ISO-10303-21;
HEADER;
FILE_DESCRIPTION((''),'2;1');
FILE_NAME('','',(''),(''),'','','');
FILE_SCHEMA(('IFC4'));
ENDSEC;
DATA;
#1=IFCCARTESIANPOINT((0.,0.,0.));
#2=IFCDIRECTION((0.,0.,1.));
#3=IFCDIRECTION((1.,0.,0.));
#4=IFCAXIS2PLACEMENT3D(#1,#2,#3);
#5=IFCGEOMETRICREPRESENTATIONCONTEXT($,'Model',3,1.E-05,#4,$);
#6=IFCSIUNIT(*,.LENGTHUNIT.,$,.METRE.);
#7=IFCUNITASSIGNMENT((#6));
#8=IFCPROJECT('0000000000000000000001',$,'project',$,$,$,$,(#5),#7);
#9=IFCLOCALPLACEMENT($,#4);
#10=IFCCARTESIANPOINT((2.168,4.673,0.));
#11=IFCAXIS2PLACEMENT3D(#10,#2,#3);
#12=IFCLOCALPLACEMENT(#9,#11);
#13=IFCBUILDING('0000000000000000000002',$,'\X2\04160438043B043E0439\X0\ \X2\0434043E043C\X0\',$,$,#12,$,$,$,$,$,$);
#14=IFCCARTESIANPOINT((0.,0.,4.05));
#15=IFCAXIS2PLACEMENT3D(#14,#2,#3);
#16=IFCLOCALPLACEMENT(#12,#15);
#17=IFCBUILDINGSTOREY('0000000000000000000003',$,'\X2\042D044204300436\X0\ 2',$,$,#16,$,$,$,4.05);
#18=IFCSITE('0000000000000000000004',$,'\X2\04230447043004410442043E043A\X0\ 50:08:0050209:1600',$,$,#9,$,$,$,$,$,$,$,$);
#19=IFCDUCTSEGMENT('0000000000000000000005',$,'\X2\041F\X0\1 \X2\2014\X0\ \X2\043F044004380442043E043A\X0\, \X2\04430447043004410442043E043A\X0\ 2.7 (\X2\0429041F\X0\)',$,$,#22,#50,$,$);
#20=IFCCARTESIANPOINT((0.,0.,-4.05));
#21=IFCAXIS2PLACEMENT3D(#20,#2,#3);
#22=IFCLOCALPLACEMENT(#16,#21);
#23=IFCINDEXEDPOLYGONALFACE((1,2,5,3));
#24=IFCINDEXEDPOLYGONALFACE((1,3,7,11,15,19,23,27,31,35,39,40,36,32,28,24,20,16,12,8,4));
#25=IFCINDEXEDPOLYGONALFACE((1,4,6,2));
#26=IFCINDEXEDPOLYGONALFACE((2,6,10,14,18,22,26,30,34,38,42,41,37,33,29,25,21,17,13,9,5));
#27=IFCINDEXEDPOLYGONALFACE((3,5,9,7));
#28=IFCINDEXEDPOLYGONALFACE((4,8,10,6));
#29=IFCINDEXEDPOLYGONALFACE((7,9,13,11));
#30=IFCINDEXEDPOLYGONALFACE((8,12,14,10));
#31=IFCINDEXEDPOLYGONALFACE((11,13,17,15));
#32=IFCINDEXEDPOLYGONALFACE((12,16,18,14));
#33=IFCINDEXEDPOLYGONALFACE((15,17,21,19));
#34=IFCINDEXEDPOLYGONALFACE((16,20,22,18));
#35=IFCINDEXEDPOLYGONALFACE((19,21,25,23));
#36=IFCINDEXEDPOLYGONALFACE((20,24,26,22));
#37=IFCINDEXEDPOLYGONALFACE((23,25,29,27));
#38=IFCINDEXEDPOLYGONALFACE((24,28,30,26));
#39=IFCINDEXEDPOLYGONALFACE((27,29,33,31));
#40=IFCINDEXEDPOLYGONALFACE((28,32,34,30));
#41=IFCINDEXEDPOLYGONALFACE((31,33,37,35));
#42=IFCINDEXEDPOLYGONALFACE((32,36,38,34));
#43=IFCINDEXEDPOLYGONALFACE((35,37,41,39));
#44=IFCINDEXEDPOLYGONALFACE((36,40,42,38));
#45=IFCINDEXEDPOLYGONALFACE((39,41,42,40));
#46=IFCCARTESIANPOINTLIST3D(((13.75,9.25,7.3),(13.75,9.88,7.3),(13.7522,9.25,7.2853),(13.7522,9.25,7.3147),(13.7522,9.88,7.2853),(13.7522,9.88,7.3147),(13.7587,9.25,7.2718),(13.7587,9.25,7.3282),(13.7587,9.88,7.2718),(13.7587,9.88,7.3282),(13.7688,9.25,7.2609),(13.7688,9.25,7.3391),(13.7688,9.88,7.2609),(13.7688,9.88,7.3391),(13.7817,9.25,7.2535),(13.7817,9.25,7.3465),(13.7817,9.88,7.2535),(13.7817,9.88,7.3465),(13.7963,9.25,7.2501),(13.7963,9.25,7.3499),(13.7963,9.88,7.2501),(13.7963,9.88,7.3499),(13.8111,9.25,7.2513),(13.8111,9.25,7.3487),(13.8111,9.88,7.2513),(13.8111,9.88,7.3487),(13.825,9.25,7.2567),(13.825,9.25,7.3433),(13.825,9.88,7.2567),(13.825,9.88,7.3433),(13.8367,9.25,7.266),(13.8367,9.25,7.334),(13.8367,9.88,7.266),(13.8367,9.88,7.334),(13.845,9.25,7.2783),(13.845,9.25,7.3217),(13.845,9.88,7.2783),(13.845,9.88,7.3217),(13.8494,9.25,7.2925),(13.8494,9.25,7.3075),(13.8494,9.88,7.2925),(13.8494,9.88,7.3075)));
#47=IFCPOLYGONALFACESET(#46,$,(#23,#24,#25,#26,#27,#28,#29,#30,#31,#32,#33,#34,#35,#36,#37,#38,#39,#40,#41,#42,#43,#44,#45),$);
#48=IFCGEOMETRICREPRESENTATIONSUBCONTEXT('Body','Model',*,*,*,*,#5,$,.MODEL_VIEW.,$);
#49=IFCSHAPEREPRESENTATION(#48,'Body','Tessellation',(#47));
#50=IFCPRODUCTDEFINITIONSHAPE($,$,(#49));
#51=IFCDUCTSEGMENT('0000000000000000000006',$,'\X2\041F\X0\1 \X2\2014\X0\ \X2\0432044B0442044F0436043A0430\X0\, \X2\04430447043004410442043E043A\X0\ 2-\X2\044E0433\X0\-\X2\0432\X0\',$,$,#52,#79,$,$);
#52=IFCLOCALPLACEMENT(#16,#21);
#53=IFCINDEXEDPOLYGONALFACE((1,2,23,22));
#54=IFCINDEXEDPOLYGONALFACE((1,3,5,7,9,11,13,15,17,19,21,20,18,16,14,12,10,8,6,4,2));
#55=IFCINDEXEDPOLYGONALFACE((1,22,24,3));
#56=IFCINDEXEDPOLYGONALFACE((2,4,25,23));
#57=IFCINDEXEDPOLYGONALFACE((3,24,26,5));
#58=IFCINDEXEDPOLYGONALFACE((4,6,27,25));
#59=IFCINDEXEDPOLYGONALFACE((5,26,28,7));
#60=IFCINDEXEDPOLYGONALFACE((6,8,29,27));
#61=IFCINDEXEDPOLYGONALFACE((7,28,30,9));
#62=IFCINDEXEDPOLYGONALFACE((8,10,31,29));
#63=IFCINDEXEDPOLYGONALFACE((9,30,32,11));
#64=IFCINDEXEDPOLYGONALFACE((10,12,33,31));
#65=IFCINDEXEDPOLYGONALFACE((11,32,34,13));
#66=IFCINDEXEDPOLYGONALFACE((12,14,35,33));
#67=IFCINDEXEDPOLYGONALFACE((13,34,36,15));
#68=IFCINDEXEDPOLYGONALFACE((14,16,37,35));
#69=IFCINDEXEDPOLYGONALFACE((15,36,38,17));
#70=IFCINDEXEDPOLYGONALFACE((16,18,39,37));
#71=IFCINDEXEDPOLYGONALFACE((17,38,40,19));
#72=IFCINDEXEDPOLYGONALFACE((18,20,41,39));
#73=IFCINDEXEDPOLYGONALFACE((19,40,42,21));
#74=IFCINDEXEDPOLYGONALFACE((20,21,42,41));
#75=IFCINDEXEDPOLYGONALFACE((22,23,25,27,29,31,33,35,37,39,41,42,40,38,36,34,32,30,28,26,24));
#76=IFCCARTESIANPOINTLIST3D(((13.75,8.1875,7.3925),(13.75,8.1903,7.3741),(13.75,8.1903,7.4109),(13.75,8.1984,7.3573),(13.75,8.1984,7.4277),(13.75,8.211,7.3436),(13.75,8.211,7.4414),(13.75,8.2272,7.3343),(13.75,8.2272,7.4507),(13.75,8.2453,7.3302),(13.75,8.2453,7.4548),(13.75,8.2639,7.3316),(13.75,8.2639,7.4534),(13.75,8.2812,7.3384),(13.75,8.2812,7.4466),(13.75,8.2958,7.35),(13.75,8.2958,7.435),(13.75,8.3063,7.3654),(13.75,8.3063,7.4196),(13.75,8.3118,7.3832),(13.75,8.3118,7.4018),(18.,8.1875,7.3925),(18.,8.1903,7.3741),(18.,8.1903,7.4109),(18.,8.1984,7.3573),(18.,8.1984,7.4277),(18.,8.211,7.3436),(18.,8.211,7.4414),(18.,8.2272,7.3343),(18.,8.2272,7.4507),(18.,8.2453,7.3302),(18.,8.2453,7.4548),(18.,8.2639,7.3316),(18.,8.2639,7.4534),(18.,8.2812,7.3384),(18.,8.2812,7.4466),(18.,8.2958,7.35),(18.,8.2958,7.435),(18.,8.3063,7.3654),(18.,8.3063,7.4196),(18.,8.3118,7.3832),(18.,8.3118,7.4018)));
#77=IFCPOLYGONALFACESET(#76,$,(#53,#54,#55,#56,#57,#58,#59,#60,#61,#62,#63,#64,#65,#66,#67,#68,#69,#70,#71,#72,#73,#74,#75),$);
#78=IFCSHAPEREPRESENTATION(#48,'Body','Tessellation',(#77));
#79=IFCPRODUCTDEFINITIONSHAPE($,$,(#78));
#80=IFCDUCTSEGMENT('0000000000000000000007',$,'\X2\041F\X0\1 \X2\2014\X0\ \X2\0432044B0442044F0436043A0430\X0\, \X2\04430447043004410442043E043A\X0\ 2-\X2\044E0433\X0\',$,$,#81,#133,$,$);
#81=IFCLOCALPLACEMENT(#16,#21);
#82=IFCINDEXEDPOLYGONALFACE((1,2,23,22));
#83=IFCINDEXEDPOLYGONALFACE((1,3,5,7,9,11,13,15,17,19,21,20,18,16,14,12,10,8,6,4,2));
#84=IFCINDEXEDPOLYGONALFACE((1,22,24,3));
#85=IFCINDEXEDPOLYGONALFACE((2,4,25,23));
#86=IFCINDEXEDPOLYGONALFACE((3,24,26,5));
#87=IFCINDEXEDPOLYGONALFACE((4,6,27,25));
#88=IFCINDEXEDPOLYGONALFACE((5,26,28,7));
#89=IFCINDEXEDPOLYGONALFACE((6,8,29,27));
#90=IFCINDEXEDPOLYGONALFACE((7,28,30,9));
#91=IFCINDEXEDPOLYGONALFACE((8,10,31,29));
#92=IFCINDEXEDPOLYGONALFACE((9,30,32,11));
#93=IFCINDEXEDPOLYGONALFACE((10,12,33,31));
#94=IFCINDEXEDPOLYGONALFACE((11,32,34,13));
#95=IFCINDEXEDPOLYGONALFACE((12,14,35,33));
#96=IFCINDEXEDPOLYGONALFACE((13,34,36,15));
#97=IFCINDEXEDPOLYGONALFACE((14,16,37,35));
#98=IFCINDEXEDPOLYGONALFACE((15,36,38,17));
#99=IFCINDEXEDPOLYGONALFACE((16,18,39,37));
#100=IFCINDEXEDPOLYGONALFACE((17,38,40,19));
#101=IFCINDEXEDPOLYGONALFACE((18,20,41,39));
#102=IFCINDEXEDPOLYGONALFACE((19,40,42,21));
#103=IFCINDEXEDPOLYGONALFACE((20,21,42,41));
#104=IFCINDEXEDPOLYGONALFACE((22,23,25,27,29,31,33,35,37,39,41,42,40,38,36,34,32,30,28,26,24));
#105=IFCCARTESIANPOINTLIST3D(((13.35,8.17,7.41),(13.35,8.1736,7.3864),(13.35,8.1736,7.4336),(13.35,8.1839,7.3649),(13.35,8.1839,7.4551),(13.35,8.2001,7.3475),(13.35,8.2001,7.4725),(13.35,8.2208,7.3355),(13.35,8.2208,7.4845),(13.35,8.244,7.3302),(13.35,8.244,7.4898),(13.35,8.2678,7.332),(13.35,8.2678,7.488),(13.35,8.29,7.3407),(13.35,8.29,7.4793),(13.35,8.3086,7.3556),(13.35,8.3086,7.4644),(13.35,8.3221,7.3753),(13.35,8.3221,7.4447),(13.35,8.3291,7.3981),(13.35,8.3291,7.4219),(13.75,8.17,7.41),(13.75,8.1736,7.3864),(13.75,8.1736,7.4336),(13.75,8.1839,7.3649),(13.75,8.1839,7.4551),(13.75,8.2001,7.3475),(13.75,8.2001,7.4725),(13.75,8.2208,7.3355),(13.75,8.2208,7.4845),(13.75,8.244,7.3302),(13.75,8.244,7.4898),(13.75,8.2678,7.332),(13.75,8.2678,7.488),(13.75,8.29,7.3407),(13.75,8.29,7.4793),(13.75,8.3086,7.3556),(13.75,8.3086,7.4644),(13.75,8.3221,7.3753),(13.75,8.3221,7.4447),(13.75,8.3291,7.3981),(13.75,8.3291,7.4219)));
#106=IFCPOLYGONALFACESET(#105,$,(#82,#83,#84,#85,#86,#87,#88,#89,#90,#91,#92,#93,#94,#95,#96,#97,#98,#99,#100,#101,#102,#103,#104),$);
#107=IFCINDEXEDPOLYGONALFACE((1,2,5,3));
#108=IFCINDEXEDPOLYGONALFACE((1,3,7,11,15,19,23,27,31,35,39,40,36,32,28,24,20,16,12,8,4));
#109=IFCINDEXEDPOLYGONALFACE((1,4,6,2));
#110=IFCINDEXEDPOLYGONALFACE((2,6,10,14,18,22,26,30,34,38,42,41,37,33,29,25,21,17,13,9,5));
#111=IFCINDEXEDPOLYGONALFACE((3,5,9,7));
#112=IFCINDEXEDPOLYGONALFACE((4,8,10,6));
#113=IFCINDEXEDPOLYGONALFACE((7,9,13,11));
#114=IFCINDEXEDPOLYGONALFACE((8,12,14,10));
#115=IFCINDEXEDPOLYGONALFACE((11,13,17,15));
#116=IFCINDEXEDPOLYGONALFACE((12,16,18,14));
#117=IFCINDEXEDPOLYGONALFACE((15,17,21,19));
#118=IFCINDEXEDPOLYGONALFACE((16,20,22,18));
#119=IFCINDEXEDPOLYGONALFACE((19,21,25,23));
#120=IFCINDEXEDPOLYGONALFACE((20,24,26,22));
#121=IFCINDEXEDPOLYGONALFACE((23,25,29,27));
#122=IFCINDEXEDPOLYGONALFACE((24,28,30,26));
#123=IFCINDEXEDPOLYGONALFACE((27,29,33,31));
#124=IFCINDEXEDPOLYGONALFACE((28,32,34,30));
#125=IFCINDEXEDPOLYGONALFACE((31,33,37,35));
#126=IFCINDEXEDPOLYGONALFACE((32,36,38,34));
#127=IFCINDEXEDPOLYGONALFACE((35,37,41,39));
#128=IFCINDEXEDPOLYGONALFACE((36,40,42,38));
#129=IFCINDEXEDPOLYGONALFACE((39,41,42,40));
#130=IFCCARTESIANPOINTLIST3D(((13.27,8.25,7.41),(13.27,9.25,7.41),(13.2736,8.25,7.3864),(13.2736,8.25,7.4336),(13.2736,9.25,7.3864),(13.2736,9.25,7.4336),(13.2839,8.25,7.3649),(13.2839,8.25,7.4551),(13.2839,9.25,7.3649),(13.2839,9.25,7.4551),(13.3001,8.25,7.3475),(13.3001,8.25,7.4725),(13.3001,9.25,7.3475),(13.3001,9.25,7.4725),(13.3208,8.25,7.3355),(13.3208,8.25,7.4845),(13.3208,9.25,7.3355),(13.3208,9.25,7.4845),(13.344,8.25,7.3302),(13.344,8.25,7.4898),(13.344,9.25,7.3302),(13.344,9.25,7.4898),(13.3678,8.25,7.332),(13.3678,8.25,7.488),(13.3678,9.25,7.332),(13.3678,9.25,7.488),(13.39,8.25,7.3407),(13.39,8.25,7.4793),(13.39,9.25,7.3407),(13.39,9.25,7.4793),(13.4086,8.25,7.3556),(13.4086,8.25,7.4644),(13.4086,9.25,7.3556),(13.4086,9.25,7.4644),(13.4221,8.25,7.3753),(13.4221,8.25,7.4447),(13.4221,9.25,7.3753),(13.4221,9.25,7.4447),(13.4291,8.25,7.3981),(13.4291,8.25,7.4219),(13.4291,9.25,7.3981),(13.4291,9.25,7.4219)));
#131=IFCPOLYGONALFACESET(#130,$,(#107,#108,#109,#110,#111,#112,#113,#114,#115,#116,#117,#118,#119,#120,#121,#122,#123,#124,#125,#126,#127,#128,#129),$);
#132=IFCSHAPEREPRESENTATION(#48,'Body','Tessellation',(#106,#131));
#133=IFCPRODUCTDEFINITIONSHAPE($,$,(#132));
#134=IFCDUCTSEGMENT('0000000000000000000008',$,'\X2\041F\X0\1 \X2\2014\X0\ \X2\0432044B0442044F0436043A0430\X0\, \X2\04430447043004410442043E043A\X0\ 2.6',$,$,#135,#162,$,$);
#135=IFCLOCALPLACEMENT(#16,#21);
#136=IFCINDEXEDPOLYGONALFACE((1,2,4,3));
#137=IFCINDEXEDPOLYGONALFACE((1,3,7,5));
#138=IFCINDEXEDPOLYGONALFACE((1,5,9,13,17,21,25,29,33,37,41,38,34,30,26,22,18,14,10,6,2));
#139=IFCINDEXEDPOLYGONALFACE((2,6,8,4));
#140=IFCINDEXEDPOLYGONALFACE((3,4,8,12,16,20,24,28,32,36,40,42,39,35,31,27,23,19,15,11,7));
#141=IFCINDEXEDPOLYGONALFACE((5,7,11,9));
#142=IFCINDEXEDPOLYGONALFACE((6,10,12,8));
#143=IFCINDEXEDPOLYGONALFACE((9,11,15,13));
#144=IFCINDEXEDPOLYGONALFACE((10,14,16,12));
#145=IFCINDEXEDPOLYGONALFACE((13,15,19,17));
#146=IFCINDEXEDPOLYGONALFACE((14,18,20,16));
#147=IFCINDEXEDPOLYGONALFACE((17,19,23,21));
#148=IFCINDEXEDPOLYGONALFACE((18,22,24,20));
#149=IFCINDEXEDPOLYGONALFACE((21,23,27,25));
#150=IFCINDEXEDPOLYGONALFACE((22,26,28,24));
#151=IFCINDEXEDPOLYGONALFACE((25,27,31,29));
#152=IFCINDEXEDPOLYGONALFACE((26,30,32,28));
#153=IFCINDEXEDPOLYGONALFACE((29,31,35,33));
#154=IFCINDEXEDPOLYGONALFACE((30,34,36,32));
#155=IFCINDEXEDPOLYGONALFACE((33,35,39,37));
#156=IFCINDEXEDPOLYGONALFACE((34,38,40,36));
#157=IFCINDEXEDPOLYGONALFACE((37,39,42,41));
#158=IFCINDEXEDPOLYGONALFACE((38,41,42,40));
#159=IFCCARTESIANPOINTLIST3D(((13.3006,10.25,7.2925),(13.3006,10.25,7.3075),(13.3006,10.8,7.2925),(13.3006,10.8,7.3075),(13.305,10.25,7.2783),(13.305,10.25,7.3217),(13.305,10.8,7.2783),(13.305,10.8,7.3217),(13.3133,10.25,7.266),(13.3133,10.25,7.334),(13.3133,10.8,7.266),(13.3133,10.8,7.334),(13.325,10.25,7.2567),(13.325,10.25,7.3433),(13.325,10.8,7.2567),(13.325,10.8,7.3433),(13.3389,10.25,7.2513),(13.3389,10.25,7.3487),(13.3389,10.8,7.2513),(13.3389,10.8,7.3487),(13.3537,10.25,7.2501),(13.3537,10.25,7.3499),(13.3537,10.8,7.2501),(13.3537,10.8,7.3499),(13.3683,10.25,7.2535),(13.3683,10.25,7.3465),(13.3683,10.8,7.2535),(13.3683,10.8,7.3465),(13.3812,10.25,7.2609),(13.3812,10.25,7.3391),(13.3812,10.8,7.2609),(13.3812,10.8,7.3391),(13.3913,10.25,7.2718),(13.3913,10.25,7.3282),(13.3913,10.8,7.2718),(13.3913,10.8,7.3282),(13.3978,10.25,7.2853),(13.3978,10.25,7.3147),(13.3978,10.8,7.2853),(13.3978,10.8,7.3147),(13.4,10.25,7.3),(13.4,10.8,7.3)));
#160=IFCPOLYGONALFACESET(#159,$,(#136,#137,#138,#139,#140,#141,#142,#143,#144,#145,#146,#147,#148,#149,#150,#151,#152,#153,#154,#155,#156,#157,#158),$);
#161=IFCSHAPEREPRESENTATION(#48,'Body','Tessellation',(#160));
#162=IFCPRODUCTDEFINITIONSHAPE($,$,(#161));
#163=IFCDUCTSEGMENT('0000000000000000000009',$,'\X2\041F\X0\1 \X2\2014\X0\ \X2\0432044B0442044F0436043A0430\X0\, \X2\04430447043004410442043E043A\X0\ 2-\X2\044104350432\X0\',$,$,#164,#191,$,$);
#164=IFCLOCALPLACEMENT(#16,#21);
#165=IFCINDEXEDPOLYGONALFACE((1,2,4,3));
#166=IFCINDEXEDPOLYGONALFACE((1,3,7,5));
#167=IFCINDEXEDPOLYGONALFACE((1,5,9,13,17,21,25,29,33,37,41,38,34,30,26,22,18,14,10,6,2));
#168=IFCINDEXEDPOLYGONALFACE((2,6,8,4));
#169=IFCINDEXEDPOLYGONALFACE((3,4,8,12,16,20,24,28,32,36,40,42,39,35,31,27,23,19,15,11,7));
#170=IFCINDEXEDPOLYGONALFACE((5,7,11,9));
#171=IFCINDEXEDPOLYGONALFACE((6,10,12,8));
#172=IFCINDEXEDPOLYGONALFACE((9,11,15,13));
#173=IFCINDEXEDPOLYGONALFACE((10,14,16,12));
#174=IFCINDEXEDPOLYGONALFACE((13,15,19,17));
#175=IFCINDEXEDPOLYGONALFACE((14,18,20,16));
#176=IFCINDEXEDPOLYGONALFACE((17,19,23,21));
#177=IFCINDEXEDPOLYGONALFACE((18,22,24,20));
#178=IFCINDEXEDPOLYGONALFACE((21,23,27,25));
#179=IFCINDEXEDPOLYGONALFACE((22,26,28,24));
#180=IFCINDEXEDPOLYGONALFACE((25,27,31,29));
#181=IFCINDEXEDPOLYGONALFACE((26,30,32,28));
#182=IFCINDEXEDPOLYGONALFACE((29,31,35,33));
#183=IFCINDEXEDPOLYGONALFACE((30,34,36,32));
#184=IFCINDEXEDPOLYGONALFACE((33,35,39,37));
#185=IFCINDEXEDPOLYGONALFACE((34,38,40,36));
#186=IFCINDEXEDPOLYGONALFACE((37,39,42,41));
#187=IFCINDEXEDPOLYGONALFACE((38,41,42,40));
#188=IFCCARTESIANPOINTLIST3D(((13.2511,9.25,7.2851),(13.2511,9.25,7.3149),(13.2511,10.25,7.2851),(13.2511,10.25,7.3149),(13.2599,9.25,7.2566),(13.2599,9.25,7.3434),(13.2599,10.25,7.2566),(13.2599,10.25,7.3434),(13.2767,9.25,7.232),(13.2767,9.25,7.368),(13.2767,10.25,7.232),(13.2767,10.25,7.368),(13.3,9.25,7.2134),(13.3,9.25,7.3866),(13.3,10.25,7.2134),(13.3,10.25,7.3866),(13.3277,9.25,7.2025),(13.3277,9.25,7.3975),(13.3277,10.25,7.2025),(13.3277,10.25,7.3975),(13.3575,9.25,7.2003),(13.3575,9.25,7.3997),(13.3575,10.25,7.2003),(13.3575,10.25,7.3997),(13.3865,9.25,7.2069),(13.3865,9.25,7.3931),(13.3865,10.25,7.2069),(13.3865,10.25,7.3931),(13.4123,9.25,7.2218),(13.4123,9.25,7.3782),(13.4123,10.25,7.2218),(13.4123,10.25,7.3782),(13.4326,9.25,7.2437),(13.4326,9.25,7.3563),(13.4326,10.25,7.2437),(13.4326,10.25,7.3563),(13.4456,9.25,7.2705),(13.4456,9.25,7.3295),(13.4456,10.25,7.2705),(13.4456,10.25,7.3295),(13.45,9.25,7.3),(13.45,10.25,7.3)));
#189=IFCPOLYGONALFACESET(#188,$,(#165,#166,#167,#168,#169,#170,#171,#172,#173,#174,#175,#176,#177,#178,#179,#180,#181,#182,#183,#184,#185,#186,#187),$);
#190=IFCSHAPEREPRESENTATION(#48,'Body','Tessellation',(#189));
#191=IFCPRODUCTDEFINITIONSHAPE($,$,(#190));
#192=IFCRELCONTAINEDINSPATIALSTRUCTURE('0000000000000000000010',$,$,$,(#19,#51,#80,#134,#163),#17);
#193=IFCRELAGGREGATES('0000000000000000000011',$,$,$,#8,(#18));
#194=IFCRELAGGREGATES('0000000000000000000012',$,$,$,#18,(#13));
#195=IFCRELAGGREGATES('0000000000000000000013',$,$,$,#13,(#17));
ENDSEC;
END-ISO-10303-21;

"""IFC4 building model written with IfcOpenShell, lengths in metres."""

from ifc_helpers import new_model, si_unit, frame, origin_with_axes, origin_2d, place, context, subcontext, project, spatial, circle, extrude, element, save


model = new_model("IFC4")

# Units and contexts
model_context = context("Model", 3, precision=1e-05, world=origin_with_axes())
body_context = subcontext(model_context, "Body", "Model", "MODEL_VIEW")
ifc_project = project(units=[si_unit("LENGTHUNIT", "METRE")], contexts=[model_context])

# Site, building, storey
site_placement = place(None, origin_with_axes())
site = spatial("IfcSite", under=ifc_project, at=site_placement, Name="Участок 50:08:0050209:1600")
building_placement = place(site_placement, frame((2.168, 4.673, 0.0), z_axis=(0.0, 0.0, 1.0), x_axis=(1.0, 0.0, 0.0)))
building = spatial("IfcBuilding", under=site, at=building_placement, Name="Жилой дом")
storey_placement = place(building_placement, frame((0.0, 0.0, 4.05), z_axis=(0.0, 0.0, 1.0), x_axis=(1.0, 0.0, 0.0)))
storey = spatial("IfcBuildingStorey", under=building, at=storey_placement, Name="Этаж 2", Elevation=4.05)

# Duct segments
duct_segment_1_placement = place(storey_placement, frame((0.0, 0.0, -4.05), z_axis=(0.0, 0.0, 1.0), x_axis=(1.0, 0.0, 0.0)))
element("IfcDuctSegment", 1, at=duct_segment_1_placement, inside=storey, Name="П1 — приток, участок 2.7 (ЩП)", context=body_context, shape_type="SweptSolid", body=[
    extrude(circle(Radius=0.05, at=origin_2d()), frame((13.8, 9.25, 7.3), z_axis=(0.0, 1.0, 0.0), x_axis=(-1.0, 0.0, 0.0)), (0.0, 0.0, 1.0), 0.63),
])
duct_segment_2_placement = place(storey_placement, frame((0.0, 0.0, -4.05), z_axis=(0.0, 0.0, 1.0), x_axis=(1.0, 0.0, 0.0)))
element("IfcDuctSegment", 2, at=duct_segment_2_placement, inside=storey, Name="П1 — вытяжка, участок 2-юг-в", context=body_context, shape_type="SweptSolid", body=[
    extrude(circle(Radius=0.0625, at=origin_2d()), frame((18.0, 8.25, 7.3925), z_axis=(-1.0, 0.0, 0.0), x_axis=(0.0, -1.0, 0.0)), (0.0, 0.0, 1.0), 4.25),
])
duct_segment_3_placement = place(storey_placement, frame((0.0, 0.0, -4.05), z_axis=(0.0, 0.0, 1.0), x_axis=(1.0, 0.0, 0.0)))
element("IfcDuctSegment", 3, at=duct_segment_3_placement, inside=storey, Name="П1 — вытяжка, участок 2-юг", context=body_context, shape_type="SweptSolid", body=[
    extrude(circle(Radius=0.08, at=origin_2d()), frame((13.75, 8.25, 7.41), z_axis=(-1.0, 0.0, 0.0), x_axis=(0.0, -1.0, 0.0)), (0.0, 0.0, 1.0), 0.4),
    extrude(circle(Radius=0.08, at=origin_2d()), frame((13.35, 8.25, 7.41), z_axis=(0.0, 1.0, 0.0), x_axis=(-1.0, 0.0, 0.0)), (0.0, 0.0, 1.0), 1.0),
])
duct_segment_4_placement = place(storey_placement, frame((0.0, 0.0, -4.05), z_axis=(0.0, 0.0, 1.0), x_axis=(1.0, 0.0, 0.0)))
element("IfcDuctSegment", 4, at=duct_segment_4_placement, inside=storey, Name="П1 — вытяжка, участок 2.6", context=body_context, shape_type="SweptSolid", body=[
    extrude(circle(Radius=0.05, at=origin_2d()), frame((13.35, 10.8, 7.3), z_axis=(0.0, -1.0, 0.0), x_axis=(1.0, 0.0, 0.0)), (0.0, 0.0, 1.0), 0.55),
])
duct_segment_5_placement = place(storey_placement, frame((0.0, 0.0, -4.05), z_axis=(0.0, 0.0, 1.0), x_axis=(1.0, 0.0, 0.0)))
element("IfcDuctSegment", 5, at=duct_segment_5_placement, inside=storey, Name="П1 — вытяжка, участок 2-сев", context=body_context, shape_type="SweptSolid", body=[
    extrude(circle(Radius=0.1, at=origin_2d()), frame((13.35, 10.25, 7.3), z_axis=(0.0, -1.0, 0.0), x_axis=(1.0, 0.0, 0.0)), (0.0, 0.0, 1.0), 1.0),
])

save(model, "model.ifc")
